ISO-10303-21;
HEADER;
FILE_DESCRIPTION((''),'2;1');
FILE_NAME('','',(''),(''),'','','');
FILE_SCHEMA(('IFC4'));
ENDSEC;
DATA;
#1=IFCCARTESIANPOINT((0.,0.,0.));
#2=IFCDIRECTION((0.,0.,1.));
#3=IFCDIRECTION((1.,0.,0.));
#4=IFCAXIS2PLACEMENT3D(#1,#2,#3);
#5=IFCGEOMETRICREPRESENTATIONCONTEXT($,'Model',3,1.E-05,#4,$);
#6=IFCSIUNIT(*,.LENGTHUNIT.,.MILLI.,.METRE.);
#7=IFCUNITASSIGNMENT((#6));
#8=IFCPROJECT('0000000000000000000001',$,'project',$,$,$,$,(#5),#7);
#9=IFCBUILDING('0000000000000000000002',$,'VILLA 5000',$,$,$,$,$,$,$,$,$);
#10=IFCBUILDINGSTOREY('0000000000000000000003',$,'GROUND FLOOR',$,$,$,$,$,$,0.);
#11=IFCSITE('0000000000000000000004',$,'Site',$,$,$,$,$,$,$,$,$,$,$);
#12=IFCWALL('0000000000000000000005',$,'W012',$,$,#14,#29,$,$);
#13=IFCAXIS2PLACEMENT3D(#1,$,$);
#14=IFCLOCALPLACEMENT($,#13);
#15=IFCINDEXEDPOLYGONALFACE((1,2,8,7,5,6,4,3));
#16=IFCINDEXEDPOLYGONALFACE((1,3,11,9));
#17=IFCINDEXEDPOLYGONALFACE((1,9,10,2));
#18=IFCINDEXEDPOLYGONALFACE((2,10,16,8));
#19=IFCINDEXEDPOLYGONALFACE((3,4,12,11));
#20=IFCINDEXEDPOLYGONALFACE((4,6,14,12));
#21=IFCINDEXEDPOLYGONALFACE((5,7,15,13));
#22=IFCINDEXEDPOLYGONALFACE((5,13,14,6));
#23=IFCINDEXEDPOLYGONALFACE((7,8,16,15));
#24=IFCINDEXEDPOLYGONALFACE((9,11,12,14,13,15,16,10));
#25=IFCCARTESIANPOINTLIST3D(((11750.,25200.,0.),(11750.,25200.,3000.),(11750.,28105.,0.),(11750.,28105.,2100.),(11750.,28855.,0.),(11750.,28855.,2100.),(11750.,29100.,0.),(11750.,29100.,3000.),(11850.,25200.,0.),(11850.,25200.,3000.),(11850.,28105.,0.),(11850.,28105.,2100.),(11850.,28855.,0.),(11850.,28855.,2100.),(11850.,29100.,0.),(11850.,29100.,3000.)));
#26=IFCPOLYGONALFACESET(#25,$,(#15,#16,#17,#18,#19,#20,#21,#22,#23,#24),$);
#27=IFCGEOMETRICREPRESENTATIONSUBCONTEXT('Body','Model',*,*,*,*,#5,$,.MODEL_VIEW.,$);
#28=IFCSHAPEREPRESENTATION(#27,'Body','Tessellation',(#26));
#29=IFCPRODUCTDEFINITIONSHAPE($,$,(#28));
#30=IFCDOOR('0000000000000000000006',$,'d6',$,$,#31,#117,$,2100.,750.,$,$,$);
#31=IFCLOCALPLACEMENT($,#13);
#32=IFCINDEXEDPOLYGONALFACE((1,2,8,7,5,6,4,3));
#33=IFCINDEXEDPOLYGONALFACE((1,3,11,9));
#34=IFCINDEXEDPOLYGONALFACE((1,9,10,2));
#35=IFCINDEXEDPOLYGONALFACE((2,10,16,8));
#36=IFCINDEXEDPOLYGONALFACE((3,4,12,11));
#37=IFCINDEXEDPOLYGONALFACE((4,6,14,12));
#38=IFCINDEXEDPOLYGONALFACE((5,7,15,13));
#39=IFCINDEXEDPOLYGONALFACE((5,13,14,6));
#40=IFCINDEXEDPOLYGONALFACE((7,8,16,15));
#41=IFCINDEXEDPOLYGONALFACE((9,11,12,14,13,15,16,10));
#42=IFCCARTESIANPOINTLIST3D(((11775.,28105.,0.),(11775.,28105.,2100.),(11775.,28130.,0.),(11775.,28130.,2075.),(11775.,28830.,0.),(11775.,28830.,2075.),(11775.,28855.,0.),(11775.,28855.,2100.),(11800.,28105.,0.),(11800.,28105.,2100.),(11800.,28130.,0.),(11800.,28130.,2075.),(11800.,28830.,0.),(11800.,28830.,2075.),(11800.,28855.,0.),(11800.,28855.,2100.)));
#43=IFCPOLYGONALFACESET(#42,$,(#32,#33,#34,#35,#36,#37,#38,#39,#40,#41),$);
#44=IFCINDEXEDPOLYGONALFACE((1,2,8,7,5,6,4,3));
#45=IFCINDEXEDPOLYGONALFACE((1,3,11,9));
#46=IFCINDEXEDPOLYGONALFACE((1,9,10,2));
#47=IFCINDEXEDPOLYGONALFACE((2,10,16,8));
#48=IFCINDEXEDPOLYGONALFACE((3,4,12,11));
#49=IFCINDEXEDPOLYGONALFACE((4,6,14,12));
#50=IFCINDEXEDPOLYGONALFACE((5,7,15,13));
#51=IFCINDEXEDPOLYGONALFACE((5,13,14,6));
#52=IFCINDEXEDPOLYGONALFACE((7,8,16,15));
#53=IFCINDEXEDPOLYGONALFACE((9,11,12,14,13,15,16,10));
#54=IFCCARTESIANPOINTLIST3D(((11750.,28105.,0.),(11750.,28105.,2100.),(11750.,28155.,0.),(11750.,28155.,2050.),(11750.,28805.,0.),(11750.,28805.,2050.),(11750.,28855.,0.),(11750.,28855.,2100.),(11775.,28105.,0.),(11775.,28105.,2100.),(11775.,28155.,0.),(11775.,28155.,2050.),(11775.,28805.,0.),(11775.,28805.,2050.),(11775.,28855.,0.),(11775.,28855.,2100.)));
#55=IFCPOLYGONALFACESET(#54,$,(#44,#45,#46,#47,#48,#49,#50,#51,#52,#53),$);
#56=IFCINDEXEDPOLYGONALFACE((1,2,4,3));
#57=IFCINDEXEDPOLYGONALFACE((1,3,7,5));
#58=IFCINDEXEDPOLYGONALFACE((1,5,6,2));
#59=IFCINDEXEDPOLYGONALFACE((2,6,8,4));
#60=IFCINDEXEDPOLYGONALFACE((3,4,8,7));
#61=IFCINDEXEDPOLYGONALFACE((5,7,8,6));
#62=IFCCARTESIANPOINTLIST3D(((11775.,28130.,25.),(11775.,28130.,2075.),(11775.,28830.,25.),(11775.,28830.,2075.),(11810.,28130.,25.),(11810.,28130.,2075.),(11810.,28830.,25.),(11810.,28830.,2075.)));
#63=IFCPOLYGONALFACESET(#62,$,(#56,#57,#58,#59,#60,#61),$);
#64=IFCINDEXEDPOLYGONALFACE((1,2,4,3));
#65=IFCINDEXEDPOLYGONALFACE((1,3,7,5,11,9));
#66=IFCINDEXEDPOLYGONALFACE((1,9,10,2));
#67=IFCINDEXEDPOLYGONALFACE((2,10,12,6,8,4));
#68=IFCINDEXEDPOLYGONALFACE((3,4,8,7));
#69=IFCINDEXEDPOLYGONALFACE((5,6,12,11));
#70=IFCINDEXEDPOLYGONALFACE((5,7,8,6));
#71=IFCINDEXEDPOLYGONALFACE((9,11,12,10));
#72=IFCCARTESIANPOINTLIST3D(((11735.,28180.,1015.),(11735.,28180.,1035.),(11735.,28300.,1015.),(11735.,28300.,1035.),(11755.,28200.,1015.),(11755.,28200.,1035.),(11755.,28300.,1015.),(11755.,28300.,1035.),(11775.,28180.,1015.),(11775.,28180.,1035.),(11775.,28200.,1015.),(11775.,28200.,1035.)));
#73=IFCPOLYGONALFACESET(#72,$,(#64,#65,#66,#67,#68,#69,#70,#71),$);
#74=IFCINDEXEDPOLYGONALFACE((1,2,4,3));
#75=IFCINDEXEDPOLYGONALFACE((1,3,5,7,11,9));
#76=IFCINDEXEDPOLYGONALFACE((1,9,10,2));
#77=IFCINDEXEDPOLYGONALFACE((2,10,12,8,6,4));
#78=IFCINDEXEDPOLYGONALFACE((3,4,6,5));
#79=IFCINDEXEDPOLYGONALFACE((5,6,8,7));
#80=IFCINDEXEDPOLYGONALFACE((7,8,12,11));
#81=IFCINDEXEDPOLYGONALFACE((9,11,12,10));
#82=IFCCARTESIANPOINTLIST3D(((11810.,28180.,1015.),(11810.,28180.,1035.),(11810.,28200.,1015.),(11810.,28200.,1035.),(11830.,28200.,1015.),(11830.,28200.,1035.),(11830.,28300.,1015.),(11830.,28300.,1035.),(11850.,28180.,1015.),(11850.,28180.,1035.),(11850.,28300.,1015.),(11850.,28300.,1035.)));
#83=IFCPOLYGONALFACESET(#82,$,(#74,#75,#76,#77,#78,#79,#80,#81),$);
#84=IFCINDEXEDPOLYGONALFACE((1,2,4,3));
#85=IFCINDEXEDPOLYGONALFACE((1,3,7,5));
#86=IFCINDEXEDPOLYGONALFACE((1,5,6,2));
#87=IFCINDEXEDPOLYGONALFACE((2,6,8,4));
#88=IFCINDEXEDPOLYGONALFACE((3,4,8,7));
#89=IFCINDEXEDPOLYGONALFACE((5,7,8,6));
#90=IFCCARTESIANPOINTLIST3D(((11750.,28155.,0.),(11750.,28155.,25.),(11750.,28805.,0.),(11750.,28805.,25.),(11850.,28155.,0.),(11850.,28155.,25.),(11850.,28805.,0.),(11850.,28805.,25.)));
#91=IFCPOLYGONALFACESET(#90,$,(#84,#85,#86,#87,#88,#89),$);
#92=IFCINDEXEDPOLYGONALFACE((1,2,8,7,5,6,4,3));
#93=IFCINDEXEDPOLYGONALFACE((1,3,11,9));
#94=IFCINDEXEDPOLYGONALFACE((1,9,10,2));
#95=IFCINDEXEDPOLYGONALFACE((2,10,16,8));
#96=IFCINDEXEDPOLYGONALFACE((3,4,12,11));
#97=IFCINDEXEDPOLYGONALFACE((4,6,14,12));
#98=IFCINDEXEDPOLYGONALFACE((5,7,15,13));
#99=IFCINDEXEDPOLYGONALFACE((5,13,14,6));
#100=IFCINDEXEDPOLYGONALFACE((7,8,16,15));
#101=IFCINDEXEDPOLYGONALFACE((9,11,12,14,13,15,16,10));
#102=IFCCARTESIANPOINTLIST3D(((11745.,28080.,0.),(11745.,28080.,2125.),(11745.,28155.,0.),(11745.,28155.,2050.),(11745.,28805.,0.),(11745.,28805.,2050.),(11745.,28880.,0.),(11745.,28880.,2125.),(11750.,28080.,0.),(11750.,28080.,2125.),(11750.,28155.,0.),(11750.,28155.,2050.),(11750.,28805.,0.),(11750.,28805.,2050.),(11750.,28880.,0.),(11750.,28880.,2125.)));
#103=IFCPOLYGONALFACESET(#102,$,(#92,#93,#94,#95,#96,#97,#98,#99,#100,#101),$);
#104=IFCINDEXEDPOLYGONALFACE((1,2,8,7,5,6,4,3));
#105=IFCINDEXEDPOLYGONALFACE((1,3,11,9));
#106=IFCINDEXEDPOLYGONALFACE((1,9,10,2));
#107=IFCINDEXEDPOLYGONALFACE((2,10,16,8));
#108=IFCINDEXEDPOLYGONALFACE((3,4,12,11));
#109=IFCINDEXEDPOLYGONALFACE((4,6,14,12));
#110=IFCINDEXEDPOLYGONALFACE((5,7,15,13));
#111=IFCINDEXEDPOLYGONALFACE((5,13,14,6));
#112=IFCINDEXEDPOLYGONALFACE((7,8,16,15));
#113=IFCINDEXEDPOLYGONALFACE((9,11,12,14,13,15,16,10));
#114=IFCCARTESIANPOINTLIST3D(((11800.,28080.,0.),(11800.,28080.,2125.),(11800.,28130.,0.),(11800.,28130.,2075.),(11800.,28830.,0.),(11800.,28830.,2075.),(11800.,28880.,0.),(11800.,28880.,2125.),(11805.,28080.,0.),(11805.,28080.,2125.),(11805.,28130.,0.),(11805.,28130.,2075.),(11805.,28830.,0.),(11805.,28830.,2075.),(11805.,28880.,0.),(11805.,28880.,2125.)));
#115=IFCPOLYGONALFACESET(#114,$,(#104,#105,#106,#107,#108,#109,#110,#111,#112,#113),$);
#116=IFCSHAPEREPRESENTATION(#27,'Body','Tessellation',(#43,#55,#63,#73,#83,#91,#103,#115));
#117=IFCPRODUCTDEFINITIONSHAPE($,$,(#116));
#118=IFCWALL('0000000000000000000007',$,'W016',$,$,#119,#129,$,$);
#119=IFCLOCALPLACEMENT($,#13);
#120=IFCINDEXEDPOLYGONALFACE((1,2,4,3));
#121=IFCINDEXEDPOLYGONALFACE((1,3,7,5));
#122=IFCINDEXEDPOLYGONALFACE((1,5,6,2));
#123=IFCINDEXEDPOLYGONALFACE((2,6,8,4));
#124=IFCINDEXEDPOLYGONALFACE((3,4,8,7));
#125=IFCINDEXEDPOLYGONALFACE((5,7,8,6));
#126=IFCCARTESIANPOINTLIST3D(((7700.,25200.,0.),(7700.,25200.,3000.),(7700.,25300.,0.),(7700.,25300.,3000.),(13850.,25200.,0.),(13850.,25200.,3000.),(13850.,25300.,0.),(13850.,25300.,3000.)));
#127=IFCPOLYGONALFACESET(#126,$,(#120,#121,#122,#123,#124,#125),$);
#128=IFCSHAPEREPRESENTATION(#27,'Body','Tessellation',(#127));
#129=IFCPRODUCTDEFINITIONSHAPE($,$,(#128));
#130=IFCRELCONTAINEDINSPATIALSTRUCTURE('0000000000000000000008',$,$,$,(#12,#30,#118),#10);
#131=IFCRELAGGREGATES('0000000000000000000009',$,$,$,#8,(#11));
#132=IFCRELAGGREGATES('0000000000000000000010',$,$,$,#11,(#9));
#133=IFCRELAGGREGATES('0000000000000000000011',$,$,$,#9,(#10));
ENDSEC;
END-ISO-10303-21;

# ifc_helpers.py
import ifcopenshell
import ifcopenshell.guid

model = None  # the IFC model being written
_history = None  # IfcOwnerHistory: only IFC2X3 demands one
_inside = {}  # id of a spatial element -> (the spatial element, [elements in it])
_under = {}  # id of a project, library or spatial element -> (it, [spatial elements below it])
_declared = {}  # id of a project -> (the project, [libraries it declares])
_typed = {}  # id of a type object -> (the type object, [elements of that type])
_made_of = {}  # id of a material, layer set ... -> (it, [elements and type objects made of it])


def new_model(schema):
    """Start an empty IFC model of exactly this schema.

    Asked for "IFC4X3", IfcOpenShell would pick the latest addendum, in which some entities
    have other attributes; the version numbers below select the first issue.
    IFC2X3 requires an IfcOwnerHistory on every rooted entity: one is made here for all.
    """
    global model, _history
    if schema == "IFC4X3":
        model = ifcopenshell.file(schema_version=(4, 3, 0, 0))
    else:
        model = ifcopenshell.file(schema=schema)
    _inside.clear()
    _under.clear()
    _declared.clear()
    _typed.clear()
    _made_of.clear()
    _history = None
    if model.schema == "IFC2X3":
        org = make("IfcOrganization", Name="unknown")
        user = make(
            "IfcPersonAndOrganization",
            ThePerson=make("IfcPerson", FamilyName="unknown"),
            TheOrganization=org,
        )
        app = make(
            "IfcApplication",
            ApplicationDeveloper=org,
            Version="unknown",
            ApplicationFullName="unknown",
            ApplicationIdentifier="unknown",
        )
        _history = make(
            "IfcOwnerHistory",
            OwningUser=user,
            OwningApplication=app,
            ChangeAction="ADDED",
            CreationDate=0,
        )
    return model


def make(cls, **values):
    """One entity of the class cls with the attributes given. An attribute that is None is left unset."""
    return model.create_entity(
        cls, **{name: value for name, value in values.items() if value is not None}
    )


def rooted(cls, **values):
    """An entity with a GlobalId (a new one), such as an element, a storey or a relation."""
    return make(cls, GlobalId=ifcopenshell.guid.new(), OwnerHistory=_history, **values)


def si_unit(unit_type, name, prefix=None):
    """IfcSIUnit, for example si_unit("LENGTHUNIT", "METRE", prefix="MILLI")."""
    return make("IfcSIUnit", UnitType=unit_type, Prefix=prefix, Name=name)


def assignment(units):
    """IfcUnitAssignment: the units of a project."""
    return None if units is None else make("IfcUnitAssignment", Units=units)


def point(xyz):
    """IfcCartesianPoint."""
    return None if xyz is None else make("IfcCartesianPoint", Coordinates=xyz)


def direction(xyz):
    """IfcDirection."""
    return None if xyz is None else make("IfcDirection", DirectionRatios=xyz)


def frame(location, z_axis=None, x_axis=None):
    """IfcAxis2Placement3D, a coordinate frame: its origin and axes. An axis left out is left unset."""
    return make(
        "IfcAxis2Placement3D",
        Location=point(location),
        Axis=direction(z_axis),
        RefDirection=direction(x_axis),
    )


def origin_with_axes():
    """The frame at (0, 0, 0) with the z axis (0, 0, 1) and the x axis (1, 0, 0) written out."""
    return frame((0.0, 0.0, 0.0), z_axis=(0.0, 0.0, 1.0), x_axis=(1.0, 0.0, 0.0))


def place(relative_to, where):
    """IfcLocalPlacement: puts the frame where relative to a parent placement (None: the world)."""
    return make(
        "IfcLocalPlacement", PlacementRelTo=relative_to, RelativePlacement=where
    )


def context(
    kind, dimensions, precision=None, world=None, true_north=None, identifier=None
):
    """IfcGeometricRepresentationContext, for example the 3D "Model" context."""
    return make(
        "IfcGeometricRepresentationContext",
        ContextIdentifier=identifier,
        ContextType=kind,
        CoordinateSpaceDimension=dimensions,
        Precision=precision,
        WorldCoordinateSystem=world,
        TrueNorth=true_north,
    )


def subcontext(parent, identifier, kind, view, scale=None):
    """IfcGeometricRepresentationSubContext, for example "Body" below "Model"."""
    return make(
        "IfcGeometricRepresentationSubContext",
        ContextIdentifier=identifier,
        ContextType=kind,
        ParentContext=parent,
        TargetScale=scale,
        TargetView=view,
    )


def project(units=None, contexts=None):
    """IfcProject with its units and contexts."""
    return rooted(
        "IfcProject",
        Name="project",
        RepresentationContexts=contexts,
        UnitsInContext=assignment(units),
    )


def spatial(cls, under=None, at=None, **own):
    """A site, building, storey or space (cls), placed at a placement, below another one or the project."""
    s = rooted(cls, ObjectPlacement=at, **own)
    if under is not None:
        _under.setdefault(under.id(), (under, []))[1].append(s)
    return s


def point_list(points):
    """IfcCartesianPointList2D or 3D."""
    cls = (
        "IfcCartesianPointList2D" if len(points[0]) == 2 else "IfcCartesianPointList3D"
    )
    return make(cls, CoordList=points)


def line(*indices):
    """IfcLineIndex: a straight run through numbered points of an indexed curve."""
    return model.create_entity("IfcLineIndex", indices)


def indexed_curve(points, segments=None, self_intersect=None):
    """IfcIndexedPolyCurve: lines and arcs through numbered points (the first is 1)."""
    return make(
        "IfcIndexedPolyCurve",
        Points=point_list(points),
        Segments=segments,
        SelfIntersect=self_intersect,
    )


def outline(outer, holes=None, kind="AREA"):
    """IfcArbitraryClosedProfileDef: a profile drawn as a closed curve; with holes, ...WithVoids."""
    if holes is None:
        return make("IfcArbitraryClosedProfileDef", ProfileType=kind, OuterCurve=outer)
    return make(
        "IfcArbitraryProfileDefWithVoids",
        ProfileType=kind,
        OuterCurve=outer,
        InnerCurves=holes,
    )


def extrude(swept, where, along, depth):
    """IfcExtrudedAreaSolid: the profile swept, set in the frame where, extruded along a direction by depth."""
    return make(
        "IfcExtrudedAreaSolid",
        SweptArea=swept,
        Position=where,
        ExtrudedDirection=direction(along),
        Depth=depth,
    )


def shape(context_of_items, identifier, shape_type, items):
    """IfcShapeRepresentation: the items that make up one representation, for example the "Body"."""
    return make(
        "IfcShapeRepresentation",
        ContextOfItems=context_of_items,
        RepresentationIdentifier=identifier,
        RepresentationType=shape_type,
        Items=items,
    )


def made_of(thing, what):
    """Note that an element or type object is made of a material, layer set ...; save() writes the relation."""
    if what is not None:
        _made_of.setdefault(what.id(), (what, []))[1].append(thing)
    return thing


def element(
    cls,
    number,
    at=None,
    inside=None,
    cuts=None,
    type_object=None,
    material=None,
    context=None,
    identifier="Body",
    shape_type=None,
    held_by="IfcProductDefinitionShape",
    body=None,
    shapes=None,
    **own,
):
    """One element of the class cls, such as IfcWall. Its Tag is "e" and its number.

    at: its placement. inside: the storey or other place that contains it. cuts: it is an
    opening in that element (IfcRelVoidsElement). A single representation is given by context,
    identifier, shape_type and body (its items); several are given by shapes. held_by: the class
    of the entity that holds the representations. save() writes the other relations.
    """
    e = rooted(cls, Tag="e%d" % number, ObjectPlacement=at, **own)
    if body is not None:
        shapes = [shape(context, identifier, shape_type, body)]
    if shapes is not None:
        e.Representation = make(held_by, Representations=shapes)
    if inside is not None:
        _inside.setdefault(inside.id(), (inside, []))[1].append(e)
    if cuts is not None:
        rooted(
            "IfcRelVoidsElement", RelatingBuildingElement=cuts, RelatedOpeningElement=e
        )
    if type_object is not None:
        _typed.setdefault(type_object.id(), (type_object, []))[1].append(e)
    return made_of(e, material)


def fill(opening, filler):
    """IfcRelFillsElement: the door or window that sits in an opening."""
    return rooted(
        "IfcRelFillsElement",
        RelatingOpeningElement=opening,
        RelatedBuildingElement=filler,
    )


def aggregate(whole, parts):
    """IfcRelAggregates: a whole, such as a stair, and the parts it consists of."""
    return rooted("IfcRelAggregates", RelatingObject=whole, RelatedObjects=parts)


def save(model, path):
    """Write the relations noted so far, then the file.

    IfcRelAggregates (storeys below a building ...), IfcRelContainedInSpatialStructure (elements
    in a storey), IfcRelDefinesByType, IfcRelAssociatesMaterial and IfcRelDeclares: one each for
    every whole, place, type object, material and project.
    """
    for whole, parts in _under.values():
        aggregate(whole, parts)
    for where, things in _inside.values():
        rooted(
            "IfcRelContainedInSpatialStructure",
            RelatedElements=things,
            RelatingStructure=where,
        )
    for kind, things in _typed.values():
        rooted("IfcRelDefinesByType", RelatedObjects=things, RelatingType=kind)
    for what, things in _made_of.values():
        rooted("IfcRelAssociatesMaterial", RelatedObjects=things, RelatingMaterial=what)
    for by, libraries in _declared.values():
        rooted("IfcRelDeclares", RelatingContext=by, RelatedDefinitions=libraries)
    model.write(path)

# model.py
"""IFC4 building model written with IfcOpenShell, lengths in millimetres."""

from ifc_helpers import new_model, si_unit, frame, origin_with_axes, place, context, subcontext, project, spatial, line, indexed_curve, outline, extrude, element, fill, save


model = new_model("IFC4")

# Units and contexts
model_context = context("Model", 3, precision=1e-05, world=origin_with_axes())
body_context = subcontext(model_context, "Body", "Model", "MODEL_VIEW")
ifc_project = project(units=[si_unit("LENGTHUNIT", "METRE", prefix="MILLI")], contexts=[model_context])

# Site, building, storey
site = spatial("IfcSite", under=ifc_project, Name="Site")
building = spatial("IfcBuilding", under=site, Name="VILLA 5000")
storey = spatial("IfcBuildingStorey", under=building, Name="GROUND FLOOR", Elevation=0.0)

# Wall, opening, door
wall_1_placement = place(None, frame((11800.0, 29100.0, 0.0), z_axis=(0.0, 0.0, 1.0), x_axis=(0.0, -1.0, 0.0)))
wall_1 = element("IfcWall", 1, at=wall_1_placement, inside=storey, Name="W012", context=body_context, shape_type="SweptSolid", body=[
    extrude(outline(indexed_curve([(0.0, 0.0), (0.0, 100.0), (3900.0, 100.0), (3900.0, 0.0), (0.0, 0.0)], self_intersect=False)), frame((0.0, -50.0, 0.0), z_axis=(0.0, 0.0, 1.0), x_axis=(1.0, 0.0, 0.0)), (0.0, 0.0, 1.0), 3000.0),
])
opening_1_placement = place(wall_1_placement, frame((245.0, 0.0, 0.0), z_axis=(0.0, 0.0, 1.0), x_axis=(1.0, 0.0, 0.0)))
opening_1 = element("IfcOpeningElement", 2, at=opening_1_placement, cuts=wall_1, context=body_context, shape_type="SweptSolid", body=[
    extrude(outline(indexed_curve([(0.0, 0.0), (0.0, 200.0), (750.0, 200.0), (750.0, 0.0), (0.0, 0.0)], self_intersect=False)), frame((0.0, -100.0, 0.0), z_axis=(0.0, 0.0, 1.0), x_axis=(1.0, 0.0, 0.0)), (0.0, 0.0, 1.0), 2100.0),
])
door_1_placement = place(None, frame((11750.0, 28855.0, 0.0), z_axis=(0.0, 0.0, 1.0), x_axis=(0.0, -1.0, 0.0)))
door_1 = element("IfcDoor", 3, at=door_1_placement, inside=storey, Name="d6", OverallHeight=2100.0, OverallWidth=750.0, context=body_context, shape_type="SweptSolid", body=[
    extrude(outline(indexed_curve([(0.0, 0.0), (0.0, 2100.0), (750.0, 2100.0), (750.0, 0.0), (725.0, 0.0), (725.0, 2075.0), (25.0, 2075.0), (25.0, 0.0)], segments=[line(1, 2, 3, 4, 5, 6, 7, 8, 1)])), frame((0.0, 25.0, 0.0), z_axis=(0.0, -1.0, 0.0), x_axis=(1.0, 0.0, 0.0)), (0.0, 0.0, -1.0), 25.0),
    extrude(outline(indexed_curve([(0.0, 0.0), (0.0, 2100.0), (750.0, 2100.0), (750.0, 0.0), (700.0, 0.0), (700.0, 2050.0), (50.0, 2050.0), (50.0, 0.0)], segments=[line(1, 2, 3, 4, 5, 6, 7, 8, 1)])), frame((0.0, 0.0, 0.0), z_axis=(0.0, -1.0, 0.0), x_axis=(1.0, 0.0, 0.0)), (0.0, 0.0, -1.0), 25.0),
    extrude(outline(indexed_curve([(0.0, 0.0), (700.0, 0.0), (700.0, 35.0), (0.0, 35.0)], segments=[line(1, 2, 3, 4, 1)])), frame((25.0, 25.0, 25.0), z_axis=(0.0, 0.0, 1.0), x_axis=(1.0, 0.0, 0.0)), (0.0, 0.0, 1.0), 2050.0),
    extrude(outline(indexed_curve([(0.0, 0.0), (0.0, -40.0), (-120.0, -40.0), (-120.0, -20.0), (-20.0, -20.0), (-20.0, 0.0)], segments=[line(1, 2, 3, 4, 5, 6, 1)])), frame((675.0, 25.0, 1015.0), z_axis=(0.0, 0.0, 1.0), x_axis=(1.0, 0.0, 0.0)), (0.0, 0.0, 1.0), 20.0),
    extrude(outline(indexed_curve([(0.0, 0.0), (0.0, 40.0), (-120.0, 40.0), (-120.0, 20.0), (-20.0, 20.0), (-20.0, 0.0)], segments=[line(1, 2, 3, 4, 5, 6, 1)])), frame((675.0, 60.0, 1015.0), z_axis=(0.0, 0.0, 1.0), x_axis=(1.0, 0.0, 0.0)), (0.0, 0.0, 1.0), 20.0),
    extrude(outline(indexed_curve([(0.0, 0.0), (650.0, 0.0), (650.0, 100.0), (0.0, 100.0)], segments=[line(1, 2, 3, 4, 1)])), frame((50.0, 0.0, 0.0), z_axis=(0.0, 0.0, 1.0), x_axis=(1.0, 0.0, 0.0)), (0.0, 0.0, 1.0), 25.0),
    extrude(outline(indexed_curve([(0.0, 0.0), (0.0, 2125.0), (800.0, 2125.0), (800.0, 0.0), (725.0, 0.0), (725.0, 2050.0), (75.0, 2050.0), (75.0, 0.0)], segments=[line(1, 2, 3, 4, 5, 6, 7, 8, 1)])), frame((-25.0, -5.0, 0.0), z_axis=(0.0, -1.0, 0.0), x_axis=(1.0, 0.0, 0.0)), (0.0, 0.0, -1.0), 5.0),
    extrude(outline(indexed_curve([(0.0, 0.0), (0.0, 2125.0), (800.0, 2125.0), (800.0, 0.0), (750.0, 0.0), (750.0, 2075.0), (50.0, 2075.0), (50.0, 0.0)], segments=[line(1, 2, 3, 4, 5, 6, 7, 8, 1)])), frame((-25.0, 50.0, 0.0), z_axis=(0.0, -1.0, 0.0), x_axis=(1.0, 0.0, 0.0)), (0.0, 0.0, -1.0), 5.0),
])
fill(opening_1, door_1)

# Wall
wall_2_placement = place(None, frame((7700.0, 25250.0, 0.0), z_axis=(0.0, 0.0, 1.0), x_axis=(1.0, 0.0, 0.0)))
element("IfcWall", 4, at=wall_2_placement, inside=storey, Name="W016", context=body_context, shape_type="SweptSolid", body=[
    extrude(outline(indexed_curve([(0.0, 0.0), (0.0, 100.0), (6150.0, 100.0), (6150.0, 0.0), (0.0, 0.0)], self_intersect=False)), frame((0.0, -50.0, 0.0), z_axis=(0.0, 0.0, 1.0), x_axis=(1.0, 0.0, 0.0)), (0.0, 0.0, 1.0), 3000.0),
])

save(model, "model.ifc")
